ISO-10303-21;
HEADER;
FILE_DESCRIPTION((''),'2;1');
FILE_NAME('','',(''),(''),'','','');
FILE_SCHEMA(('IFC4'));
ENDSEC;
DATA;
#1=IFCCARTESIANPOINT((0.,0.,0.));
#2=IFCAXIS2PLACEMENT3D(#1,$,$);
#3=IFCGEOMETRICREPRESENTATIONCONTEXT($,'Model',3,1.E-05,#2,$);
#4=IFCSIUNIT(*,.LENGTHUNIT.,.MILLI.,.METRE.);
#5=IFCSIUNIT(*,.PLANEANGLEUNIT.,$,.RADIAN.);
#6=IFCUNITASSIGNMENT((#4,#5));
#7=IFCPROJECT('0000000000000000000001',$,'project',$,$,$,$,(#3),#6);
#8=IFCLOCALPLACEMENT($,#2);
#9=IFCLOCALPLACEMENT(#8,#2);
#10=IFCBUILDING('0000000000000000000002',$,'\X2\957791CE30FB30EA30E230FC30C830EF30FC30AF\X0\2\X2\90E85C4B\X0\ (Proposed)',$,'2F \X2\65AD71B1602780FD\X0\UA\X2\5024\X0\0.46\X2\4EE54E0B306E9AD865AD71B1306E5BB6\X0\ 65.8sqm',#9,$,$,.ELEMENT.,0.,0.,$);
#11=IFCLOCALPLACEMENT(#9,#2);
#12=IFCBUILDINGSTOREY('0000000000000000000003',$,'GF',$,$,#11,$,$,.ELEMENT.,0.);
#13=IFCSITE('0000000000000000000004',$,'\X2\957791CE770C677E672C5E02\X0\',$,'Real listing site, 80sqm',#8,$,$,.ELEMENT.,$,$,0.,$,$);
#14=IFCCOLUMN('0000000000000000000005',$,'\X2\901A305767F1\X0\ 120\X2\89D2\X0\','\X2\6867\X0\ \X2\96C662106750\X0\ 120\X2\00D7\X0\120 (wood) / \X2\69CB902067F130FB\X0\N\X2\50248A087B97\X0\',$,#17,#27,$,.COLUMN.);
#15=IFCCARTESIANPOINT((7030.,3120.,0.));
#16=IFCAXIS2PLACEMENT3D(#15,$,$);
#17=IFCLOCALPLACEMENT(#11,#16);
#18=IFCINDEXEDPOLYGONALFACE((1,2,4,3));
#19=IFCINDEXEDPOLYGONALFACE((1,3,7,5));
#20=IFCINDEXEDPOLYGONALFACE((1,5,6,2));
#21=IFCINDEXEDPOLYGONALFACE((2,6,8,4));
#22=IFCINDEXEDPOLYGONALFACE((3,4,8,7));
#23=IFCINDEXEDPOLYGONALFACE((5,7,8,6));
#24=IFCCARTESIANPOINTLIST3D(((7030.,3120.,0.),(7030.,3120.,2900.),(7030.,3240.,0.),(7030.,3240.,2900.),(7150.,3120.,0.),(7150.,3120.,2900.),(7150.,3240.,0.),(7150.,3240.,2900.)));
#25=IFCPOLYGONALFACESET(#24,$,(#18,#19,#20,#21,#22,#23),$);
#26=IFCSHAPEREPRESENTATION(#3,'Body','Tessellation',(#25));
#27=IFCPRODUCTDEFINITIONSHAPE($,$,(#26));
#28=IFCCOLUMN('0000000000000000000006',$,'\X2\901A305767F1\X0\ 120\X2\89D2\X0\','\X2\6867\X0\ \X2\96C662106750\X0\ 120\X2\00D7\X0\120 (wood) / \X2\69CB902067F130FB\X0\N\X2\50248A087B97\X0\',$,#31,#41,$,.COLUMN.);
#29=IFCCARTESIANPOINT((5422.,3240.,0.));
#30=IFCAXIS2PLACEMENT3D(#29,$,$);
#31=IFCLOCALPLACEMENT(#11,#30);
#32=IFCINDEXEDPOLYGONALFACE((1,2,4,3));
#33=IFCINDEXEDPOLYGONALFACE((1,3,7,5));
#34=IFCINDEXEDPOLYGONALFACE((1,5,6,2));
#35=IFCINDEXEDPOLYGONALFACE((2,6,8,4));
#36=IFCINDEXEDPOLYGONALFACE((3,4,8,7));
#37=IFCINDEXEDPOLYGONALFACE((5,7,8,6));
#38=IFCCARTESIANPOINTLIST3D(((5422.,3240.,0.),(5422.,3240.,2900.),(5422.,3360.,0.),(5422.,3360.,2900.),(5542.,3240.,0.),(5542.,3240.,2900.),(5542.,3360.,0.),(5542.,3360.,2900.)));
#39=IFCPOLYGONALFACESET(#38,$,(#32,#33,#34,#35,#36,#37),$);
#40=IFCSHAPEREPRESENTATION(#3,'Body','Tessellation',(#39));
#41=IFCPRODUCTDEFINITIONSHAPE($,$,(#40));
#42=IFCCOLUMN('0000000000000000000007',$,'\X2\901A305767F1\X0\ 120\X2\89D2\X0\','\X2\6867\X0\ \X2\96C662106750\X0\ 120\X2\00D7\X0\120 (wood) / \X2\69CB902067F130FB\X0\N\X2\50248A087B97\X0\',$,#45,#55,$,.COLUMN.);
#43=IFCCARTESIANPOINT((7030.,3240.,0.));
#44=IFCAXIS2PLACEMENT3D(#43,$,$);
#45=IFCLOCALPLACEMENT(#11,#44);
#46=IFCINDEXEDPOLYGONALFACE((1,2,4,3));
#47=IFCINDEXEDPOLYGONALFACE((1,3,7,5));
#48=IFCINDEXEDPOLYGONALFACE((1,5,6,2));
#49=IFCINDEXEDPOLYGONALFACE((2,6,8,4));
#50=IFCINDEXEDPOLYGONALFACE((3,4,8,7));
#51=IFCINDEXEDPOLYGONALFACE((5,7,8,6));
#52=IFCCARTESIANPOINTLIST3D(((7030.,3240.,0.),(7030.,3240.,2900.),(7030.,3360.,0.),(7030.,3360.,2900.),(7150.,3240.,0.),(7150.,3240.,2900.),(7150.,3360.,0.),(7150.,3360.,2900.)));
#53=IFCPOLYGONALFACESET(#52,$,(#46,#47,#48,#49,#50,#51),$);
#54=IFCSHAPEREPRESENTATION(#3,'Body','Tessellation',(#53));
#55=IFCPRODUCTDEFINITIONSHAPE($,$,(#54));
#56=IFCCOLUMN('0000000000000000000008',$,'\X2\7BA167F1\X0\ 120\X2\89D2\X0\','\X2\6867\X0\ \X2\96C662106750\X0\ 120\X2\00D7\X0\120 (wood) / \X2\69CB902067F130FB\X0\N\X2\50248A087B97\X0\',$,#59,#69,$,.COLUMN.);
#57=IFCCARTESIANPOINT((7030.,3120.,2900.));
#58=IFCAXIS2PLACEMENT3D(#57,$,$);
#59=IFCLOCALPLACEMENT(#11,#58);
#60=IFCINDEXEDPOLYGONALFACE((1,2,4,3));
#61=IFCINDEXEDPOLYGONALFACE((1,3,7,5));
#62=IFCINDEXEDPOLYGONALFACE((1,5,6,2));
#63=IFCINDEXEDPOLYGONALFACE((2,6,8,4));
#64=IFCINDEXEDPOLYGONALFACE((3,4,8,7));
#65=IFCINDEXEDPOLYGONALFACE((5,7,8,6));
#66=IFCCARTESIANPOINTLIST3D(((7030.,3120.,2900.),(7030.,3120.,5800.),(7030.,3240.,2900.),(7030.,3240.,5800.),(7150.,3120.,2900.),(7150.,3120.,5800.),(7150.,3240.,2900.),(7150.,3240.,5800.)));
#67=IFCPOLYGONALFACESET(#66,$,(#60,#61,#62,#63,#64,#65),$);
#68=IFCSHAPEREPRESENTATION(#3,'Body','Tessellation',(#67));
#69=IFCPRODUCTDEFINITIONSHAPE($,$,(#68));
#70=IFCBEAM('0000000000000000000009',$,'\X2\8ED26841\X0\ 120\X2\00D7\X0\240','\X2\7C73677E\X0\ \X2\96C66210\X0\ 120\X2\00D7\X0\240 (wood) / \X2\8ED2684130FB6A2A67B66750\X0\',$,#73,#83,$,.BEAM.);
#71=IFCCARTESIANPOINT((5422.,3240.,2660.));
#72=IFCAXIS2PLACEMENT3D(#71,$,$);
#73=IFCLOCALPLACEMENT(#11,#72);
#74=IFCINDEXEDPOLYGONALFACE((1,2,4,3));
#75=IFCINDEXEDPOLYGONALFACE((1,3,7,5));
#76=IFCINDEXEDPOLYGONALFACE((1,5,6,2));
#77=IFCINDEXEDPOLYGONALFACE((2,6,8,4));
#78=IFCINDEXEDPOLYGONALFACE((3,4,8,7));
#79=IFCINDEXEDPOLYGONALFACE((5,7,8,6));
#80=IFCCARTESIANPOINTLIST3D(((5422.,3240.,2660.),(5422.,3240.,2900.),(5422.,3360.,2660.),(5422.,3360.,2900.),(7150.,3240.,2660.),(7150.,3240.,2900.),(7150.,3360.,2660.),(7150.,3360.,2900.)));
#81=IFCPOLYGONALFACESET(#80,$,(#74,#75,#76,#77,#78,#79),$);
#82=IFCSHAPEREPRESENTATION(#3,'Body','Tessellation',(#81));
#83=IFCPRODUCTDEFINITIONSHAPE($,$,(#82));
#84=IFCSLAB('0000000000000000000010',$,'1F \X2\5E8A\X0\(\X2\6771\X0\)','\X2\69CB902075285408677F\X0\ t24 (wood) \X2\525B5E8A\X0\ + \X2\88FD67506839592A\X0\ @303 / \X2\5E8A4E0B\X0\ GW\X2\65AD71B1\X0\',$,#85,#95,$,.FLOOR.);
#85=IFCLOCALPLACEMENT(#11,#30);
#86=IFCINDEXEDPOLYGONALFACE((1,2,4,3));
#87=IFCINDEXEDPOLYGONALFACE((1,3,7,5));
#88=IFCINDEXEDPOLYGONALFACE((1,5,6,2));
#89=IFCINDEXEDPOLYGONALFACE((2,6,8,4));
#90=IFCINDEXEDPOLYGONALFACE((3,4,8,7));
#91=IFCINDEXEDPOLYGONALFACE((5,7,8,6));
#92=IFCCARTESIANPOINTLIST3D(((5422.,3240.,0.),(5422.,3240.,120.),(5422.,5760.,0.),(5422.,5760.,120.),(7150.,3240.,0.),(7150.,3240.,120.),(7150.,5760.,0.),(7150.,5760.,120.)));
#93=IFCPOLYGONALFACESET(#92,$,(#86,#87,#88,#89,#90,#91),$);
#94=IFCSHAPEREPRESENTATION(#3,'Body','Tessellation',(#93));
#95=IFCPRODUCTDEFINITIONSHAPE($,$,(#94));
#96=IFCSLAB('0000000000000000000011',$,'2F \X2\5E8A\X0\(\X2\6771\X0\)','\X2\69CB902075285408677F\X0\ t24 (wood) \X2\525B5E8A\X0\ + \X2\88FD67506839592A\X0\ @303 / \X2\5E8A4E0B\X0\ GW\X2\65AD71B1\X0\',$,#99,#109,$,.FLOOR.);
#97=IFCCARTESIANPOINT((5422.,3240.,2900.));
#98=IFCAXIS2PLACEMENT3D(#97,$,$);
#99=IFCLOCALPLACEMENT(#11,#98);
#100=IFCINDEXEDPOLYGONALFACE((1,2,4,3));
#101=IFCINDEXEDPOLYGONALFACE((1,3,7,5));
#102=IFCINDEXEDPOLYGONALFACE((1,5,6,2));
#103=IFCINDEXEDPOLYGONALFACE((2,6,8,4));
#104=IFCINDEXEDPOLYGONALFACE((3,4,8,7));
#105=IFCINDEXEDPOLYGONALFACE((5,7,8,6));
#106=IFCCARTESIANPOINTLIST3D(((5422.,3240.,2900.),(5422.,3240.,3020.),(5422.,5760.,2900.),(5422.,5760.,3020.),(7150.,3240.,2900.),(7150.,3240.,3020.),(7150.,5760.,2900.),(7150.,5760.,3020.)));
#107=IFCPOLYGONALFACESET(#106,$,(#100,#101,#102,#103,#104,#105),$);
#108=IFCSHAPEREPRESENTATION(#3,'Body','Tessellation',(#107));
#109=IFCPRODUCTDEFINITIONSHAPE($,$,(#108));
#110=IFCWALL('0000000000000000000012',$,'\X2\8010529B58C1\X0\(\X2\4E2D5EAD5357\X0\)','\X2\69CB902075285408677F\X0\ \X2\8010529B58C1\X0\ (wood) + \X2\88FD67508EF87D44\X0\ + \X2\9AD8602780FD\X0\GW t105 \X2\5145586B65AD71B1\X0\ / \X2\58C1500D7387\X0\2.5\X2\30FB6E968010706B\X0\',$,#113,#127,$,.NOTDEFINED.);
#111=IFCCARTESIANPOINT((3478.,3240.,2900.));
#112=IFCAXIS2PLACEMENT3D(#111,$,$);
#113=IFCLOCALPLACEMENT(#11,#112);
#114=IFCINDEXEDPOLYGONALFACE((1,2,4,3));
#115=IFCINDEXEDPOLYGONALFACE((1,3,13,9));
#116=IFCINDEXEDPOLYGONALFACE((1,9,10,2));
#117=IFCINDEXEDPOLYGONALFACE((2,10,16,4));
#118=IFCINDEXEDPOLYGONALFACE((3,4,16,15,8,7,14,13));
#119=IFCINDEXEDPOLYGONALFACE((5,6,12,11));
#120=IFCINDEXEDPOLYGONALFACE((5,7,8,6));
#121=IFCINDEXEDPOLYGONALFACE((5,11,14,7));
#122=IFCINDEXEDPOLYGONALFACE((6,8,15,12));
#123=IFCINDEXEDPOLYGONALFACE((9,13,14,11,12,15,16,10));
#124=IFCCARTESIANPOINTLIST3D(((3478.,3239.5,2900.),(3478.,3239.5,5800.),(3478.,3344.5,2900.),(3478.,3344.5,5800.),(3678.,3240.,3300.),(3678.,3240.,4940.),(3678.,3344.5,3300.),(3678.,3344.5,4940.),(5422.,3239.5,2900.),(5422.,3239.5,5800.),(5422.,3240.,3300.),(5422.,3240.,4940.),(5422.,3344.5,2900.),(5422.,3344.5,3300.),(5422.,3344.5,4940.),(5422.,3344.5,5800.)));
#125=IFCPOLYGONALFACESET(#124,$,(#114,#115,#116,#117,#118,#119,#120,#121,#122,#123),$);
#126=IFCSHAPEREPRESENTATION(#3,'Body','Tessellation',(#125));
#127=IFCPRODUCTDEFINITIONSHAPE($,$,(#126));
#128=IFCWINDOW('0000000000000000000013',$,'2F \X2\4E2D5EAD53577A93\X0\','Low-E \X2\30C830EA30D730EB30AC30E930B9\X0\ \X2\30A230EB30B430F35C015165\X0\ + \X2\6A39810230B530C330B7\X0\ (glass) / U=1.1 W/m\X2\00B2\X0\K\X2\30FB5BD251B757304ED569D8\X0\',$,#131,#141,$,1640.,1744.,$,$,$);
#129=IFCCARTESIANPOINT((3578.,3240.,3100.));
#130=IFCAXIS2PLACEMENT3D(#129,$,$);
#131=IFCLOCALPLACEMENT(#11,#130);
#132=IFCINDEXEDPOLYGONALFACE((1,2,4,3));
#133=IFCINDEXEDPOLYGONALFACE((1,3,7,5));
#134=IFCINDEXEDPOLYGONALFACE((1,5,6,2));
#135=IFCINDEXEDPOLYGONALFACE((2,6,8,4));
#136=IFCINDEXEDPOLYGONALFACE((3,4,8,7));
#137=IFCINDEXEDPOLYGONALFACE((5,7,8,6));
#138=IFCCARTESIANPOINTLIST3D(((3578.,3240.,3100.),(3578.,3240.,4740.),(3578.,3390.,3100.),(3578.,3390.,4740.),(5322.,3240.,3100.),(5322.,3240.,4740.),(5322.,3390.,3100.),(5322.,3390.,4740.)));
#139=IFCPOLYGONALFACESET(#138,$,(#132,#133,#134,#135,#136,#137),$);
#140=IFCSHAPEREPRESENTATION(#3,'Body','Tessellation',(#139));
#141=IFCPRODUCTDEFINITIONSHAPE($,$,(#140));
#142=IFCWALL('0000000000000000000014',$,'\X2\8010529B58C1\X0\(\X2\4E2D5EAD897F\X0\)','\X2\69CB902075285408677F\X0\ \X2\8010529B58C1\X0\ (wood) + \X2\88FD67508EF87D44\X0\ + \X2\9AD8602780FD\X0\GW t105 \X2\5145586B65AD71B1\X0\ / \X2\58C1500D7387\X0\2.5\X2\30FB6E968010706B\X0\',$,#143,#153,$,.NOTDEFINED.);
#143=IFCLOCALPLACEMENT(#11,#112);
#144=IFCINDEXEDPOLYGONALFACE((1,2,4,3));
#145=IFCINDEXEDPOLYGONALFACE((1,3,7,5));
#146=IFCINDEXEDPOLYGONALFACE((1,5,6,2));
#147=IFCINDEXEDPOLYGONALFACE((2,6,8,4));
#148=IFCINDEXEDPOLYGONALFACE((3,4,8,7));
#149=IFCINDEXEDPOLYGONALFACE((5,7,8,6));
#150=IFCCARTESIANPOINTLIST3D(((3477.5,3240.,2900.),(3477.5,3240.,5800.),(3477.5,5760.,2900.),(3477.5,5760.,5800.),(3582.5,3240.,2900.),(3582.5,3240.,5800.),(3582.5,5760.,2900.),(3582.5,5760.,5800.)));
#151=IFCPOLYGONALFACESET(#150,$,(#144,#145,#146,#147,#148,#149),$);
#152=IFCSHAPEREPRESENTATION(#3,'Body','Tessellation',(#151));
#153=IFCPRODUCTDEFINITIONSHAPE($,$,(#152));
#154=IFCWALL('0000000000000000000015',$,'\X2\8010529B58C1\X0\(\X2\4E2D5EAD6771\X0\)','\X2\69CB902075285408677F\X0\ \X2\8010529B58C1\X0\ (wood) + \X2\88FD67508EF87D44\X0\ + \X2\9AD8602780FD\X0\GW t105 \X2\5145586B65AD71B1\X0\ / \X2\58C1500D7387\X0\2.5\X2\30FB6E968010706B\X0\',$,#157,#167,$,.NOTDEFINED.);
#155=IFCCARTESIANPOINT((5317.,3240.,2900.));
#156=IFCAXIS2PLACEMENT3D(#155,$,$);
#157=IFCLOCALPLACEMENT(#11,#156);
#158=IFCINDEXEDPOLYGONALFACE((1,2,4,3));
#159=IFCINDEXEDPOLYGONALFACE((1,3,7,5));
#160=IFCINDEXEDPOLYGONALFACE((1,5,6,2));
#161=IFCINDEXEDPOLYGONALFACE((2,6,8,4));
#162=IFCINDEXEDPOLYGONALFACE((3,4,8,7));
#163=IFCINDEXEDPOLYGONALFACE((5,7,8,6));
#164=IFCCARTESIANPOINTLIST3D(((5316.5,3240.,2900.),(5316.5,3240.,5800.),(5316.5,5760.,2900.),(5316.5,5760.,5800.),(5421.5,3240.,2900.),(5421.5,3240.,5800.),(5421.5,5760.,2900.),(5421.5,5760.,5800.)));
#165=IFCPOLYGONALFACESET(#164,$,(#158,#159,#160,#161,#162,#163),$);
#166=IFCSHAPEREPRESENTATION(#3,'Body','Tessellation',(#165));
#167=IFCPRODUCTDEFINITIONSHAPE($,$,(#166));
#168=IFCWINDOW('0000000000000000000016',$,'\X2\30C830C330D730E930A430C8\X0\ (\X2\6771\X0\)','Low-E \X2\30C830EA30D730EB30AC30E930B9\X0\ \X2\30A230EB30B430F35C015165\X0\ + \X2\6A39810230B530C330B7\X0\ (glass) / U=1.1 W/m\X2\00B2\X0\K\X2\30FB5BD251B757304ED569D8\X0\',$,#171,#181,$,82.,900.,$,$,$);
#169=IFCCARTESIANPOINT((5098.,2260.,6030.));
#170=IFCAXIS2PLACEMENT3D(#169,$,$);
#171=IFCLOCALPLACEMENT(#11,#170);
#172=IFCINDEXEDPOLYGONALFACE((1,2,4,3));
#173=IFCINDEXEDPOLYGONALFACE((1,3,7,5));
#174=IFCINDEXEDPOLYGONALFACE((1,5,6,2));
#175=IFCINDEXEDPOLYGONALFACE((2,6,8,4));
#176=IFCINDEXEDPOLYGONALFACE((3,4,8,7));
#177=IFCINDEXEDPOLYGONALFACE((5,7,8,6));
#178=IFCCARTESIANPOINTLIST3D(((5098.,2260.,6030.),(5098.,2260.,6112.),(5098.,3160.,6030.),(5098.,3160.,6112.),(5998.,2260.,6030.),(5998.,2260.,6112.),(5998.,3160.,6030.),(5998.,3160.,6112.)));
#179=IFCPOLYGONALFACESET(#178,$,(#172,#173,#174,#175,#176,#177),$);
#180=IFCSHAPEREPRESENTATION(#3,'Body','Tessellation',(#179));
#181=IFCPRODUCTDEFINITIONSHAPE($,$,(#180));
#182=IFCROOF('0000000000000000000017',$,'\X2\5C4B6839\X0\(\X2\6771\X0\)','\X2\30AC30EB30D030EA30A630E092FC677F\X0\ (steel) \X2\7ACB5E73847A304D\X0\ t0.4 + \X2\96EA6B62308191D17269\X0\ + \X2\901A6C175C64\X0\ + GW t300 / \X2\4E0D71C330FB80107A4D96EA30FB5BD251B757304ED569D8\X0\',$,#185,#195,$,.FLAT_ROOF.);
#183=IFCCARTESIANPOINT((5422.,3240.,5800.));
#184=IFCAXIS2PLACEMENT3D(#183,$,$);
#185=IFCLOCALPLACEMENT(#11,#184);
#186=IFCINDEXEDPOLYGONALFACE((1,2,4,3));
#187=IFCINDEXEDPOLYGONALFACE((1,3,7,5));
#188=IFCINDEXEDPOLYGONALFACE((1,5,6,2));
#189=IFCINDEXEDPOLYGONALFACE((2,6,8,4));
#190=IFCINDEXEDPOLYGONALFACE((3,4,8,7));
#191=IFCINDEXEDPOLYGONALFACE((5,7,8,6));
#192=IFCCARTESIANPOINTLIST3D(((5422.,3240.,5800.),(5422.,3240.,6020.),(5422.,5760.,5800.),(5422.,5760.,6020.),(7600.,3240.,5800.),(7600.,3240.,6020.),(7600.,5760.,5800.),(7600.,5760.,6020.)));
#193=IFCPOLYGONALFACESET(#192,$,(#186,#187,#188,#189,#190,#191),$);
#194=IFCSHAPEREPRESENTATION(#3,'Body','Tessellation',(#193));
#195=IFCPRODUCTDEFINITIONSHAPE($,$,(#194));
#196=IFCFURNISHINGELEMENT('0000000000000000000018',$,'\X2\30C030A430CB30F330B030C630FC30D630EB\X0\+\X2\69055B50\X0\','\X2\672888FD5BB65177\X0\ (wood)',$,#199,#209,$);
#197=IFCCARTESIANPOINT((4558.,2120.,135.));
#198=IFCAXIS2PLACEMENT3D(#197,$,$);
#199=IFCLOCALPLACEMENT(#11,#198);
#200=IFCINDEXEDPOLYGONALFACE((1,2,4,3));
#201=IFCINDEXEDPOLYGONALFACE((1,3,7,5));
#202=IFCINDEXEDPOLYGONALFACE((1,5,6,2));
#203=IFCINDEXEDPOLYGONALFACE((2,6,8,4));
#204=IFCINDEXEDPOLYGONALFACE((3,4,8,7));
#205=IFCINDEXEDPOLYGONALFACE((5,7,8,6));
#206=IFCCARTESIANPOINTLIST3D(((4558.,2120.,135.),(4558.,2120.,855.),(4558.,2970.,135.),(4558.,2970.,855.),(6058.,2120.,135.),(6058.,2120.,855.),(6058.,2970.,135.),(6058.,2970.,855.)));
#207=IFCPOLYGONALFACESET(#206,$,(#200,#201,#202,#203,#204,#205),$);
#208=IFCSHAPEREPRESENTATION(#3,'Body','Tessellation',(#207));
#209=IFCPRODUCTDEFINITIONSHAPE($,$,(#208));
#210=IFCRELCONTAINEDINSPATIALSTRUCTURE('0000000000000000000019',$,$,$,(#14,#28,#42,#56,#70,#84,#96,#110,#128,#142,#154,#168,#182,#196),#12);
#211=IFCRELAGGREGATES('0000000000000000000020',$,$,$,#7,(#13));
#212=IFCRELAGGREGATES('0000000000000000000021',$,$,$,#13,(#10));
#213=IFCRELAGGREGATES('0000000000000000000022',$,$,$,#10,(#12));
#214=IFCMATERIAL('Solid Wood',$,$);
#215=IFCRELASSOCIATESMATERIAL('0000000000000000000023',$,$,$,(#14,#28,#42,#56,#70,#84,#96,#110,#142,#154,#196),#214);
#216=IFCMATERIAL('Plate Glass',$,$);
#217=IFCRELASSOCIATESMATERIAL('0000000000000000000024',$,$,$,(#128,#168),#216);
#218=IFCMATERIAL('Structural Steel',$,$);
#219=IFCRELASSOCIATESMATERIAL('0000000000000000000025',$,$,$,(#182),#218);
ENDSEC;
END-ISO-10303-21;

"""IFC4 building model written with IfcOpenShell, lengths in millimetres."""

from ifc_helpers import new_model, si_unit, frame, frame_2d, origin, place, context, project, spatial, rectangle, extrude, material, element, fill, save


model = new_model("IFC4")

# Units and contexts
model_context = context("Model", 3, precision=1e-05, world=origin())
ifc_project = project(units=[si_unit("LENGTHUNIT", "METRE", prefix="MILLI"), si_unit("PLANEANGLEUNIT", "RADIAN")], contexts=[model_context])

# Site, building, storey
site_placement = place(None, origin())
site = spatial("IfcSite", under=ifc_project, at=site_placement, Name="長野県松本市", ObjectType="Real listing site, 80sqm", CompositionType="ELEMENT", RefElevation=0.0)
building_placement = place(site_placement, origin())
building = spatial("IfcBuilding", under=site, at=building_placement, Name="長野・リモートワーク2部屋 (Proposed)", ObjectType="2F 断熱性能UA値0.46以下の高断熱の家 65.8sqm", CompositionType="ELEMENT", ElevationOfRefHeight=0.0, ElevationOfTerrain=0.0)
storey_placement = place(building_placement, origin())
storey = spatial("IfcBuildingStorey", under=building, at=storey_placement, Name="GF", CompositionType="ELEMENT", Elevation=0.0)

# Columns
ifc_material_1 = material(Name="Solid Wood")
column_1_placement = place(storey_placement, frame((7030.0, 3120.0, 0.0)))
element("IfcColumn", 1, at=column_1_placement, inside=storey, material=ifc_material_1, Name="通し柱 120角", Description="桧 集成材 120×120 (wood) / 構造柱・N値計算", PredefinedType="COLUMN", context=model_context, shape_type="SweptSolid", body=[
    extrude(rectangle(XDim=120.0, YDim=120.0, at=frame_2d((60.0, 60.0))), frame((7030.0, 3120.0, 0.0)), (0.0, 0.0, 1.0), 2900.0),
])
column_2_placement = place(storey_placement, frame((5422.0, 3240.0, 0.0)))
element("IfcColumn", 2, at=column_2_placement, inside=storey, material=ifc_material_1, Name="通し柱 120角", Description="桧 集成材 120×120 (wood) / 構造柱・N値計算", PredefinedType="COLUMN", context=model_context, shape_type="SweptSolid", body=[
    extrude(rectangle(XDim=120.0, YDim=120.0, at=frame_2d((60.0, 60.0))), frame((5422.0, 3240.0, 0.0)), (0.0, 0.0, 1.0), 2900.0),
])
column_3_placement = place(storey_placement, frame((7030.0, 3240.0, 0.0)))
element("IfcColumn", 3, at=column_3_placement, inside=storey, material=ifc_material_1, Name="通し柱 120角", Description="桧 集成材 120×120 (wood) / 構造柱・N値計算", PredefinedType="COLUMN", context=model_context, shape_type="SweptSolid", body=[
    extrude(rectangle(XDim=120.0, YDim=120.0, at=frame_2d((60.0, 60.0))), frame((7030.0, 3240.0, 0.0)), (0.0, 0.0, 1.0), 2900.0),
])
column_4_placement = place(storey_placement, frame((7030.0, 3120.0, 2900.0)))
element("IfcColumn", 4, at=column_4_placement, inside=storey, material=ifc_material_1, Name="管柱 120角", Description="桧 集成材 120×120 (wood) / 構造柱・N値計算", PredefinedType="COLUMN", context=model_context, shape_type="SweptSolid", body=[
    extrude(rectangle(XDim=120.0, YDim=120.0, at=frame_2d((60.0, 60.0))), frame((7030.0, 3120.0, 2900.0)), (0.0, 0.0, 1.0), 2900.0),
])

# Beam
beam_1_placement = place(storey_placement, frame((5422.0, 3240.0, 2660.0)))
element("IfcBeam", 5, at=beam_1_placement, inside=storey, material=ifc_material_1, Name="軒桁 120×240", Description="米松 集成 120×240 (wood) / 軒桁・横架材", PredefinedType="BEAM", context=model_context, shape_type="SweptSolid", body=[
    extrude(rectangle(XDim=1728.0, YDim=120.0, at=frame_2d((864.0, 60.0))), frame((5422.0, 3240.0, 2660.0)), (0.0, 0.0, 1.0), 240.0),
])

# Slabs
slab_1_placement = place(storey_placement, frame((5422.0, 3240.0, 0.0)))
element("IfcSlab", 6, at=slab_1_placement, inside=storey, material=ifc_material_1, Name="1F 床(東)", Description="構造用合板 t24 (wood) 剛床 + 製材根太 @303 / 床下 GW断熱", PredefinedType="FLOOR", context=model_context, shape_type="SweptSolid", body=[
    extrude(rectangle(XDim=1728.0, YDim=2520.0, at=frame_2d((864.0, 1260.0))), frame((5422.0, 3240.0, 0.0)), (0.0, 0.0, 1.0), 120.0),
])
slab_2_placement = place(storey_placement, frame((5422.0, 3240.0, 2900.0)))
element("IfcSlab", 7, at=slab_2_placement, inside=storey, material=ifc_material_1, Name="2F 床(東)", Description="構造用合板 t24 (wood) 剛床 + 製材根太 @303 / 床下 GW断熱", PredefinedType="FLOOR", context=model_context, shape_type="SweptSolid", body=[
    extrude(rectangle(XDim=1728.0, YDim=2520.0, at=frame_2d((864.0, 1260.0))), frame((5422.0, 3240.0, 2900.0)), (0.0, 0.0, 1.0), 120.0),
])

# Wall, opening, window
wall_1_placement = place(storey_placement, frame((3478.0, 3240.0, 2900.0)))
wall_1 = element("IfcWall", 8, at=wall_1_placement, inside=storey, material=ifc_material_1, Name="耐力壁(中庭南)", Description="構造用合板 耐力壁 (wood) + 製材軸組 + 高性能GW t105 充填断熱 / 壁倍率2.5・準耐火", PredefinedType="NOTDEFINED", context=model_context, shape_type="SweptSolid", body=[
    extrude(rectangle(XDim=1944.0, YDim=105.0, at=frame_2d((972.0, 52.0))), frame((3478.0, 3240.0, 2900.0)), (0.0, 0.0, 1.0), 2900.0),
])
opening_placement = place(storey_placement, frame((3578.0, 3240.0, 3100.0)))
opening = element("IfcOpeningElement", 9, at=opening_placement, cuts=wall_1, PredefinedType="NOTDEFINED", context=model_context, shape_type="SweptSolid", body=[
    extrude(rectangle(XDim=1744.0, YDim=150.0, at=frame_2d((872.0, 75.0))), frame((3578.0, 3240.0, 3100.0)), (0.0, 0.0, 1.0), 1640.0),
])
ifc_material_2 = material(Name="Plate Glass")
window_1_placement = place(storey_placement, frame((3578.0, 3240.0, 3100.0)))
window_1 = element("IfcWindow", 10, at=window_1_placement, inside=storey, material=ifc_material_2, Name="2F 中庭南窓", Description="Low-E トリプルガラス アルゴン封入 + 樹脂サッシ (glass) / U=1.1 W/m²K・寒冷地仕様", OverallHeight=1640.0, OverallWidth=1744.0, context=model_context, shape_type="SweptSolid", body=[
    extrude(rectangle(XDim=1744.0, YDim=150.0, at=frame_2d((872.0, 75.0))), frame((3578.0, 3240.0, 3100.0)), (0.0, 0.0, 1.0), 1640.0),
])
fill(opening, window_1)

# Walls
wall_2_placement = place(storey_placement, frame((3478.0, 3240.0, 2900.0)))
element("IfcWall", 11, at=wall_2_placement, inside=storey, material=ifc_material_1, Name="耐力壁(中庭西)", Description="構造用合板 耐力壁 (wood) + 製材軸組 + 高性能GW t105 充填断熱 / 壁倍率2.5・準耐火", PredefinedType="NOTDEFINED", context=model_context, shape_type="SweptSolid", body=[
    extrude(rectangle(XDim=105.0, YDim=2520.0, at=frame_2d((52.0, 1260.0))), frame((3478.0, 3240.0, 2900.0)), (0.0, 0.0, 1.0), 2900.0),
])
wall_3_placement = place(storey_placement, frame((5317.0, 3240.0, 2900.0)))
element("IfcWall", 12, at=wall_3_placement, inside=storey, material=ifc_material_1, Name="耐力壁(中庭東)", Description="構造用合板 耐力壁 (wood) + 製材軸組 + 高性能GW t105 充填断熱 / 壁倍率2.5・準耐火", PredefinedType="NOTDEFINED", context=model_context, shape_type="SweptSolid", body=[
    extrude(rectangle(XDim=105.0, YDim=2520.0, at=frame_2d((52.0, 1260.0))), frame((5317.0, 3240.0, 2900.0)), (0.0, 0.0, 1.0), 2900.0),
])

# Window
window_2_placement = place(storey_placement, frame((5098.0, 2260.0, 6030.0)))
element("IfcWindow", 13, at=window_2_placement, inside=storey, material=ifc_material_2, Name="トップライト (東)", Description="Low-E トリプルガラス アルゴン封入 + 樹脂サッシ (glass) / U=1.1 W/m²K・寒冷地仕様", OverallHeight=82.0, OverallWidth=900.0, context=model_context, shape_type="SweptSolid", body=[
    extrude(rectangle(XDim=900.0, YDim=900.0, at=frame_2d((450.0, 450.0))), frame((5098.0, 2260.0, 6030.0)), (0.0, 0.0, 1.0), 82.0),
])

# Roof
ifc_material_3 = material(Name="Structural Steel")
for number, where, name in (
    (14, (5422.0, 3240.0, 5800.0), "屋根(東)"),
):
    element("IfcRoof", number, at=place(storey_placement, frame(where)), inside=storey, material=ifc_material_3, Name=name, Description="ガルバリウム鋼板 (steel) 立平葺き t0.4 + 雪止め金物 + 通気層 + GW t300 / 不燃・耐積雪・寒冷地仕様", PredefinedType="FLAT_ROOF", context=model_context, shape_type="SweptSolid", body=[
        extrude(rectangle(XDim=2178.0, YDim=2520.0, at=frame_2d((1089.0, 1260.0))), frame((5422.0, 3240.0, 5800.0)), (0.0, 0.0, 1.0), 220.0),
    ])

# Furnishing element
furnishing_1_placement = place(storey_placement, frame((4558.0, 2120.0, 135.0)))
element("IfcFurnishingElement", 15, at=furnishing_1_placement, inside=storey, material=ifc_material_1, Name="ダイニングテーブル+椅子", Description="木製家具 (wood)", context=model_context, shape_type="SweptSolid", body=[
    extrude(rectangle(XDim=1500.0, YDim=850.0, at=frame_2d((750.0, 425.0))), frame((4558.0, 2120.0, 135.0)), (0.0, 0.0, 1.0), 720.0),
])

save(model, "model.ifc")
